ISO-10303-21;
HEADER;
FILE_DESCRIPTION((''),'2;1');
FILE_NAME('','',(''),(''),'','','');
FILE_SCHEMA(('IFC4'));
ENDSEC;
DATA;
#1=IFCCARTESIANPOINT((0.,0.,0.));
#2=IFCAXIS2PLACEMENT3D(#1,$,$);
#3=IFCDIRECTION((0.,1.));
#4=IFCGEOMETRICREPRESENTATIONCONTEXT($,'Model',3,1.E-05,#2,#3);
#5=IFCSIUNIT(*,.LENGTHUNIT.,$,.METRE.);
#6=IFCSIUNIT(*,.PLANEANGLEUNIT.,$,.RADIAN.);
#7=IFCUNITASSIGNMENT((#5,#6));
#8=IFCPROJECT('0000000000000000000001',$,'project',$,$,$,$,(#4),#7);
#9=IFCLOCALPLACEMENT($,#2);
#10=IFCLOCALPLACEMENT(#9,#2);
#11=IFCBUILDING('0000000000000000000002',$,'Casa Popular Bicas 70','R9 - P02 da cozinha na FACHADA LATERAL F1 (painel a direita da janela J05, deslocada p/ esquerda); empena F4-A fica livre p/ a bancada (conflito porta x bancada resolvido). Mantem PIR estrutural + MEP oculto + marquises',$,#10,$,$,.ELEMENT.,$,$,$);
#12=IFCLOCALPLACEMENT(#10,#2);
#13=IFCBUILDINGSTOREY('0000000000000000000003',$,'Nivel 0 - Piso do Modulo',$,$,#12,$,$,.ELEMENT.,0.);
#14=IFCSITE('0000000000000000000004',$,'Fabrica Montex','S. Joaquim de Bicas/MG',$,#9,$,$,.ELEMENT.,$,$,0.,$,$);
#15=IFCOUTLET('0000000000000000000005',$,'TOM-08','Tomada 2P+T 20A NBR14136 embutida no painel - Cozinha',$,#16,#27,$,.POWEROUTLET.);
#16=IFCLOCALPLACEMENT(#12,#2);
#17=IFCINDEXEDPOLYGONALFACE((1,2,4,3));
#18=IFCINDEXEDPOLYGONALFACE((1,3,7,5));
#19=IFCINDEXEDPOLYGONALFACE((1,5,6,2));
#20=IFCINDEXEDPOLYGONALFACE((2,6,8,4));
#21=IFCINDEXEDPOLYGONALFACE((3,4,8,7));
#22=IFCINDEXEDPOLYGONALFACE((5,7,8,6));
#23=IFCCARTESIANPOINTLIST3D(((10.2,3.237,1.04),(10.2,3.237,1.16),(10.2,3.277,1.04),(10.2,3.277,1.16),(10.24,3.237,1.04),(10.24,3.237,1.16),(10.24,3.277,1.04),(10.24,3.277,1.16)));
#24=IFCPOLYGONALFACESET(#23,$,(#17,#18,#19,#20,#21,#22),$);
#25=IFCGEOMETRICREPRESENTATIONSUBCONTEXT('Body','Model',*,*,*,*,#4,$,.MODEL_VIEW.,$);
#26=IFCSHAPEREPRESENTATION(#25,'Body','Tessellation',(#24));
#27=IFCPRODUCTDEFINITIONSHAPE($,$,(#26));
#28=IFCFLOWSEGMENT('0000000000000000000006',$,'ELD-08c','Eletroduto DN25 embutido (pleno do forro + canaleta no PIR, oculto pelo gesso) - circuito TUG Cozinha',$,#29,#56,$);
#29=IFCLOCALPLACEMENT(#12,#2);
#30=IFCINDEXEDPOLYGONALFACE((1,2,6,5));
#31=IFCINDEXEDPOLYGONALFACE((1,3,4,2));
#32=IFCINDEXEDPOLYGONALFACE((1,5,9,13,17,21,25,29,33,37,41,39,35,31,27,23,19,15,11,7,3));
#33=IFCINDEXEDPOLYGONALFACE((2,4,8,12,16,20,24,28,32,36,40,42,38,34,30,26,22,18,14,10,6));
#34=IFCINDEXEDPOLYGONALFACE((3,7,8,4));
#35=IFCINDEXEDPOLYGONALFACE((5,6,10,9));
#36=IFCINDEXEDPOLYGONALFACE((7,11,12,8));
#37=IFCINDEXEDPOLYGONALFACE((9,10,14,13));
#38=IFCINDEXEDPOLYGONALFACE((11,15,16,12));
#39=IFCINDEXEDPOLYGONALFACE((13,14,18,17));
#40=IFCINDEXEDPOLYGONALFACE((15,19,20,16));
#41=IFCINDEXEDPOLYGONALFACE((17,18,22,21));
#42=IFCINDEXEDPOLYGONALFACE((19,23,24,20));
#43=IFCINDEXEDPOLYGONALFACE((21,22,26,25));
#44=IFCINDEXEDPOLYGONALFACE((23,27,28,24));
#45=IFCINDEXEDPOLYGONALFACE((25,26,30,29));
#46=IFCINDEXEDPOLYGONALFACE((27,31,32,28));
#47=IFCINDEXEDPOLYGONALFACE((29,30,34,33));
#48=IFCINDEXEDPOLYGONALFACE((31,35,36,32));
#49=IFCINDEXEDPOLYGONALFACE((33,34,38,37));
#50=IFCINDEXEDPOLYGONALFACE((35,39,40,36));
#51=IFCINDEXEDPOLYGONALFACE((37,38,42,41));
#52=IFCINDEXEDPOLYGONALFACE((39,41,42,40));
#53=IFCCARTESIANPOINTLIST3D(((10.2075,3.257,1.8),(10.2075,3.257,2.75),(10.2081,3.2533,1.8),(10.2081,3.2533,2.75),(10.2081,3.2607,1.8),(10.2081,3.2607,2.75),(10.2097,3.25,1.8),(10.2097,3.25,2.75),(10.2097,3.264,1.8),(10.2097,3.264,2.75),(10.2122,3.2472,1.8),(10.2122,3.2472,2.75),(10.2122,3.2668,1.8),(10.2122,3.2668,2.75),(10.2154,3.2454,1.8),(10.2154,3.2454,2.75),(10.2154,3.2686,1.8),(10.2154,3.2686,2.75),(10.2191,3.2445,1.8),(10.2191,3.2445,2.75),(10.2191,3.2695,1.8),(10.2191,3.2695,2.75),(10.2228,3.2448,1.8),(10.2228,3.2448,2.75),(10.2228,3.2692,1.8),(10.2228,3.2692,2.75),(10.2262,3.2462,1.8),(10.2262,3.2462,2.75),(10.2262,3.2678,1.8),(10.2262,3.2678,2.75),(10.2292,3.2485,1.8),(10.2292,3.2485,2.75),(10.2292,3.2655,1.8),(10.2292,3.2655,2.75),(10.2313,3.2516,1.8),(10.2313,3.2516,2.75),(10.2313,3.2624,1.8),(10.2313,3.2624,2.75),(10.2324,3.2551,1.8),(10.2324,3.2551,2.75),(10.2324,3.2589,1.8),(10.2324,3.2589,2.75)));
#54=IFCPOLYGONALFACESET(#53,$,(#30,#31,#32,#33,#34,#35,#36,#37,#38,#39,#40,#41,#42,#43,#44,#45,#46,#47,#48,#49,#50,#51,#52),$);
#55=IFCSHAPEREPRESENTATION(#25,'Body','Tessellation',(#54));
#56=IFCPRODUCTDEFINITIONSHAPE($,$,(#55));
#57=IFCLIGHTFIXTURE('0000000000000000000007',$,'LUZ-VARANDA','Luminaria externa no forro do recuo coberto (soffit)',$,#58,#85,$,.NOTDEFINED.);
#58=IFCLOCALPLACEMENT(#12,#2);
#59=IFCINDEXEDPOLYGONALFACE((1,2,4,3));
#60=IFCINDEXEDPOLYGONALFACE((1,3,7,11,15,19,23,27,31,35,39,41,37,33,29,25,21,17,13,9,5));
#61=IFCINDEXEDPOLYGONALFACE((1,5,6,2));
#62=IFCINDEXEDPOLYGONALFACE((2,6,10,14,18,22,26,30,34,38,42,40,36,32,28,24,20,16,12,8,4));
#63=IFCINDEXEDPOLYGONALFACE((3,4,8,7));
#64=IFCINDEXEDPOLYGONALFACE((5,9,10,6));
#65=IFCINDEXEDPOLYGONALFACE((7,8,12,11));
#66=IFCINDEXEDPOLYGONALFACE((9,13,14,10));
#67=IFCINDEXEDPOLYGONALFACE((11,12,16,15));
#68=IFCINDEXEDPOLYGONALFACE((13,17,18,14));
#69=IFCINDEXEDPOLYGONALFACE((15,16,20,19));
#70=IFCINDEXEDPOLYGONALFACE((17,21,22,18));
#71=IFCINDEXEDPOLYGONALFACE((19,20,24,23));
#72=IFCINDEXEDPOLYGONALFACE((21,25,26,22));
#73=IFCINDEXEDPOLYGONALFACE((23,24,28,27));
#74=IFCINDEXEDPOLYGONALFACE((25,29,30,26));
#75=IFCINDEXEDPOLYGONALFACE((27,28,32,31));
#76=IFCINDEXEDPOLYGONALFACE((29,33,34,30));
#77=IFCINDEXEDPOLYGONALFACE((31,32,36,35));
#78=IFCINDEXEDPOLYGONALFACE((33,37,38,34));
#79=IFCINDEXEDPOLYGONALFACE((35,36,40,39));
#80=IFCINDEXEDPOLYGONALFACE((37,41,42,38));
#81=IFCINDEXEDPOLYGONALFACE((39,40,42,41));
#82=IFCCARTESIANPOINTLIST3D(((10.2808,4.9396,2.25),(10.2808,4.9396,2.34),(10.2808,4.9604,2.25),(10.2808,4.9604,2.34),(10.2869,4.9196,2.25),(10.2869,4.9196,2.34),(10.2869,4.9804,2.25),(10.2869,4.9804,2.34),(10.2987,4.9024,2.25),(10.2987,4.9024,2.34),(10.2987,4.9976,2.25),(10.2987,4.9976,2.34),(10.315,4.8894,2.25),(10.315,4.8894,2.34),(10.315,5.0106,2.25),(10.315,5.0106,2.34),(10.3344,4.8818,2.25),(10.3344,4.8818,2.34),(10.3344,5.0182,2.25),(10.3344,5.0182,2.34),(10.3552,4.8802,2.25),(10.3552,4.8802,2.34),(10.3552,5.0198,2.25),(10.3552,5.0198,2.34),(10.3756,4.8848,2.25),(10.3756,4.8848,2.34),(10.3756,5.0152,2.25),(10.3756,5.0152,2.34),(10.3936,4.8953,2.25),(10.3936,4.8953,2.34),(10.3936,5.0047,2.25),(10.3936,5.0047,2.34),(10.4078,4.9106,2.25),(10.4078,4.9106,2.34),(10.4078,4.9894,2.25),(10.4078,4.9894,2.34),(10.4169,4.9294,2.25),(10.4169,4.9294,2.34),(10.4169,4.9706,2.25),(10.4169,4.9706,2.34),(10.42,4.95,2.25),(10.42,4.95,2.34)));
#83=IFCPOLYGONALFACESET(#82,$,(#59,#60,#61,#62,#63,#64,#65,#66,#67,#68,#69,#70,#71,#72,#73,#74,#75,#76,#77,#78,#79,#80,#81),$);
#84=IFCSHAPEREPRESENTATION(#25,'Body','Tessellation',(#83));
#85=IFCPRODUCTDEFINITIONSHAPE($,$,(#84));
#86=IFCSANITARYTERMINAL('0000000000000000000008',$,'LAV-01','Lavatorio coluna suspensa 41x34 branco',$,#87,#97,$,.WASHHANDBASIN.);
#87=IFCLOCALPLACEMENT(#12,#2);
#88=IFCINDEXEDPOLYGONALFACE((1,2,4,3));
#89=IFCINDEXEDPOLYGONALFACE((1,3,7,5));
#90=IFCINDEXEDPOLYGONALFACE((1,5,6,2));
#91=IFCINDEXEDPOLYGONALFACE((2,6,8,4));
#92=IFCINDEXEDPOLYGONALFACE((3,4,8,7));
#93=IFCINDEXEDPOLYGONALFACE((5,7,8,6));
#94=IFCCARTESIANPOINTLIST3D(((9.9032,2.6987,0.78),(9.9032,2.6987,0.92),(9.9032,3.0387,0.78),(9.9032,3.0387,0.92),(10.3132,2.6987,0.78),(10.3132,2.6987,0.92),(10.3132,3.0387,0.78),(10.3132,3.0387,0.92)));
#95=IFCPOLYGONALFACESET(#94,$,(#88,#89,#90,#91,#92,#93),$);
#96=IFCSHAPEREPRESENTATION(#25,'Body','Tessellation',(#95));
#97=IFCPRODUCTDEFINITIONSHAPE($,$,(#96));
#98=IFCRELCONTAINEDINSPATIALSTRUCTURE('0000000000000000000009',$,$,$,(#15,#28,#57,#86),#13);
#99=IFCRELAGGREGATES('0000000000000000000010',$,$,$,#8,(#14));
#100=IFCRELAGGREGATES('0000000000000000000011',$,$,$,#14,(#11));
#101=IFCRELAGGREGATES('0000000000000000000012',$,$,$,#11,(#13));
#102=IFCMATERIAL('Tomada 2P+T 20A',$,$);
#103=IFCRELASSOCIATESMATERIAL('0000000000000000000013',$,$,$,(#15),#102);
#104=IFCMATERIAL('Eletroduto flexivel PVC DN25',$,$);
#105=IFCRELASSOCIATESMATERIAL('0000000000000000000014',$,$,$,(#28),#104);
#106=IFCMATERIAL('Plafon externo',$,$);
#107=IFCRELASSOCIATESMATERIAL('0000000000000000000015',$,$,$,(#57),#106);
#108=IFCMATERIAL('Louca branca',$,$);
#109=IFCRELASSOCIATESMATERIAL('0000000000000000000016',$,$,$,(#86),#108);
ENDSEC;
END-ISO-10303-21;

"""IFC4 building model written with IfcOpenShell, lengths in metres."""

from ifc_helpers import new_model, si_unit, direction, frame, frame_2d, origin, origin_2d, place, context, subcontext, project, spatial, rectangle, circle, extrude, material, element, save


model = new_model("IFC4")

# Units and contexts
model_context = context("Model", 3, precision=1e-05, world=origin(), true_north=direction((0.0, 1.0)))
body_context = subcontext(model_context, "Body", "Model", "MODEL_VIEW")
ifc_project = project(units=[si_unit("LENGTHUNIT", "METRE"), si_unit("PLANEANGLEUNIT", "RADIAN")], contexts=[model_context])

# Site, building, storey
site_placement = place(None, origin())
site = spatial("IfcSite", under=ifc_project, at=site_placement, Name="Fabrica Montex", Description="S. Joaquim de Bicas/MG", CompositionType="ELEMENT", RefElevation=0.0)
building_placement = place(site_placement, origin())
building = spatial("IfcBuilding", under=site, at=building_placement, Name="Casa Popular Bicas 70", Description="R9 - P02 da cozinha na FACHADA LATERAL F1 (painel a direita da janela J05, deslocada p/ esquerda); empena F4-A fica livre p/ a bancada (conflito porta x bancada resolvido). Mantem PIR estrutural + MEP oculto + marquises", CompositionType="ELEMENT")
storey_placement = place(building_placement, origin())
storey = spatial("IfcBuildingStorey", under=building, at=storey_placement, Name="Nivel 0 - Piso do Modulo", CompositionType="ELEMENT", Elevation=0.0)

# Shared definitions
ifc_material_1 = material(Name="Eletroduto flexivel PVC DN25")

# Outlet
ifc_material_2 = material(Name="Tomada 2P+T 20A")
outlet_1_placement = place(None, frame((10.24, 3.277, 1.04), z_axis=(0.0, 0.0, 1.0), x_axis=(-1.0, 0.0, 0.0)))
element("IfcOutlet", 1, at=outlet_1_placement, inside=storey, material=ifc_material_2, Name="TOM-08", Description="Tomada 2P+T 20A NBR14136 embutida no painel - Cozinha", PredefinedType="POWEROUTLET", context=body_context, shape_type="SweptSolid", body=[
    extrude(rectangle(XDim=0.04, YDim=0.04, at=frame_2d((0.02, 0.02))), origin(), (0.0, 0.0, 1.0), 0.12),
])

# Flow segment
flow_segment_1_placement = place(None, frame((10.22, 3.257, 2.75), z_axis=(0.0, 0.0, -1.0), x_axis=(-1.0, 0.0, 0.0)))
element("IfcFlowSegment", 2, at=flow_segment_1_placement, inside=storey, material=ifc_material_1, Name="ELD-08c", Description="Eletroduto DN25 embutido (pleno do forro + canaleta no PIR, oculto pelo gesso) - circuito TUG Cozinha", context=body_context, shape_type="SweptSolid", body=[
    extrude(circle(Radius=0.0125, at=origin_2d()), origin(), (0.0, 0.0, 1.0), 0.95),
])

# Light fixture
ifc_material_3 = material(Name="Plafon externo")
light_fixture_placement = place(storey_placement, frame((10.35, 4.95, 2.25)))
element("IfcLightFixture", 3, at=light_fixture_placement, inside=storey, material=ifc_material_3, Name="LUZ-VARANDA", Description="Luminaria externa no forro do recuo coberto (soffit)", PredefinedType="NOTDEFINED", context=body_context, shape_type="SweptSolid", body=[
    extrude(circle(Radius=0.07, at=origin_2d()), origin(), (0.0, 0.0, 1.0), 0.09),
])

# Sanitary terminal
ifc_material_4 = material(Name="Louca branca")
sanitary_terminal_placement = place(None, frame((10.3132, 3.0387, 0.78), z_axis=(0.0, 0.0, 1.0), x_axis=(-1.0, 0.0, 0.0)))
element("IfcSanitaryTerminal", 4, at=sanitary_terminal_placement, inside=storey, material=ifc_material_4, Name="LAV-01", Description="Lavatorio coluna suspensa 41x34 branco", PredefinedType="WASHHANDBASIN", context=body_context, shape_type="SweptSolid", body=[
    extrude(rectangle(XDim=0.41, YDim=0.34, at=frame_2d((0.205, 0.17))), origin(), (0.0, 0.0, 1.0), 0.14),
])

save(model, "model.ifc")
